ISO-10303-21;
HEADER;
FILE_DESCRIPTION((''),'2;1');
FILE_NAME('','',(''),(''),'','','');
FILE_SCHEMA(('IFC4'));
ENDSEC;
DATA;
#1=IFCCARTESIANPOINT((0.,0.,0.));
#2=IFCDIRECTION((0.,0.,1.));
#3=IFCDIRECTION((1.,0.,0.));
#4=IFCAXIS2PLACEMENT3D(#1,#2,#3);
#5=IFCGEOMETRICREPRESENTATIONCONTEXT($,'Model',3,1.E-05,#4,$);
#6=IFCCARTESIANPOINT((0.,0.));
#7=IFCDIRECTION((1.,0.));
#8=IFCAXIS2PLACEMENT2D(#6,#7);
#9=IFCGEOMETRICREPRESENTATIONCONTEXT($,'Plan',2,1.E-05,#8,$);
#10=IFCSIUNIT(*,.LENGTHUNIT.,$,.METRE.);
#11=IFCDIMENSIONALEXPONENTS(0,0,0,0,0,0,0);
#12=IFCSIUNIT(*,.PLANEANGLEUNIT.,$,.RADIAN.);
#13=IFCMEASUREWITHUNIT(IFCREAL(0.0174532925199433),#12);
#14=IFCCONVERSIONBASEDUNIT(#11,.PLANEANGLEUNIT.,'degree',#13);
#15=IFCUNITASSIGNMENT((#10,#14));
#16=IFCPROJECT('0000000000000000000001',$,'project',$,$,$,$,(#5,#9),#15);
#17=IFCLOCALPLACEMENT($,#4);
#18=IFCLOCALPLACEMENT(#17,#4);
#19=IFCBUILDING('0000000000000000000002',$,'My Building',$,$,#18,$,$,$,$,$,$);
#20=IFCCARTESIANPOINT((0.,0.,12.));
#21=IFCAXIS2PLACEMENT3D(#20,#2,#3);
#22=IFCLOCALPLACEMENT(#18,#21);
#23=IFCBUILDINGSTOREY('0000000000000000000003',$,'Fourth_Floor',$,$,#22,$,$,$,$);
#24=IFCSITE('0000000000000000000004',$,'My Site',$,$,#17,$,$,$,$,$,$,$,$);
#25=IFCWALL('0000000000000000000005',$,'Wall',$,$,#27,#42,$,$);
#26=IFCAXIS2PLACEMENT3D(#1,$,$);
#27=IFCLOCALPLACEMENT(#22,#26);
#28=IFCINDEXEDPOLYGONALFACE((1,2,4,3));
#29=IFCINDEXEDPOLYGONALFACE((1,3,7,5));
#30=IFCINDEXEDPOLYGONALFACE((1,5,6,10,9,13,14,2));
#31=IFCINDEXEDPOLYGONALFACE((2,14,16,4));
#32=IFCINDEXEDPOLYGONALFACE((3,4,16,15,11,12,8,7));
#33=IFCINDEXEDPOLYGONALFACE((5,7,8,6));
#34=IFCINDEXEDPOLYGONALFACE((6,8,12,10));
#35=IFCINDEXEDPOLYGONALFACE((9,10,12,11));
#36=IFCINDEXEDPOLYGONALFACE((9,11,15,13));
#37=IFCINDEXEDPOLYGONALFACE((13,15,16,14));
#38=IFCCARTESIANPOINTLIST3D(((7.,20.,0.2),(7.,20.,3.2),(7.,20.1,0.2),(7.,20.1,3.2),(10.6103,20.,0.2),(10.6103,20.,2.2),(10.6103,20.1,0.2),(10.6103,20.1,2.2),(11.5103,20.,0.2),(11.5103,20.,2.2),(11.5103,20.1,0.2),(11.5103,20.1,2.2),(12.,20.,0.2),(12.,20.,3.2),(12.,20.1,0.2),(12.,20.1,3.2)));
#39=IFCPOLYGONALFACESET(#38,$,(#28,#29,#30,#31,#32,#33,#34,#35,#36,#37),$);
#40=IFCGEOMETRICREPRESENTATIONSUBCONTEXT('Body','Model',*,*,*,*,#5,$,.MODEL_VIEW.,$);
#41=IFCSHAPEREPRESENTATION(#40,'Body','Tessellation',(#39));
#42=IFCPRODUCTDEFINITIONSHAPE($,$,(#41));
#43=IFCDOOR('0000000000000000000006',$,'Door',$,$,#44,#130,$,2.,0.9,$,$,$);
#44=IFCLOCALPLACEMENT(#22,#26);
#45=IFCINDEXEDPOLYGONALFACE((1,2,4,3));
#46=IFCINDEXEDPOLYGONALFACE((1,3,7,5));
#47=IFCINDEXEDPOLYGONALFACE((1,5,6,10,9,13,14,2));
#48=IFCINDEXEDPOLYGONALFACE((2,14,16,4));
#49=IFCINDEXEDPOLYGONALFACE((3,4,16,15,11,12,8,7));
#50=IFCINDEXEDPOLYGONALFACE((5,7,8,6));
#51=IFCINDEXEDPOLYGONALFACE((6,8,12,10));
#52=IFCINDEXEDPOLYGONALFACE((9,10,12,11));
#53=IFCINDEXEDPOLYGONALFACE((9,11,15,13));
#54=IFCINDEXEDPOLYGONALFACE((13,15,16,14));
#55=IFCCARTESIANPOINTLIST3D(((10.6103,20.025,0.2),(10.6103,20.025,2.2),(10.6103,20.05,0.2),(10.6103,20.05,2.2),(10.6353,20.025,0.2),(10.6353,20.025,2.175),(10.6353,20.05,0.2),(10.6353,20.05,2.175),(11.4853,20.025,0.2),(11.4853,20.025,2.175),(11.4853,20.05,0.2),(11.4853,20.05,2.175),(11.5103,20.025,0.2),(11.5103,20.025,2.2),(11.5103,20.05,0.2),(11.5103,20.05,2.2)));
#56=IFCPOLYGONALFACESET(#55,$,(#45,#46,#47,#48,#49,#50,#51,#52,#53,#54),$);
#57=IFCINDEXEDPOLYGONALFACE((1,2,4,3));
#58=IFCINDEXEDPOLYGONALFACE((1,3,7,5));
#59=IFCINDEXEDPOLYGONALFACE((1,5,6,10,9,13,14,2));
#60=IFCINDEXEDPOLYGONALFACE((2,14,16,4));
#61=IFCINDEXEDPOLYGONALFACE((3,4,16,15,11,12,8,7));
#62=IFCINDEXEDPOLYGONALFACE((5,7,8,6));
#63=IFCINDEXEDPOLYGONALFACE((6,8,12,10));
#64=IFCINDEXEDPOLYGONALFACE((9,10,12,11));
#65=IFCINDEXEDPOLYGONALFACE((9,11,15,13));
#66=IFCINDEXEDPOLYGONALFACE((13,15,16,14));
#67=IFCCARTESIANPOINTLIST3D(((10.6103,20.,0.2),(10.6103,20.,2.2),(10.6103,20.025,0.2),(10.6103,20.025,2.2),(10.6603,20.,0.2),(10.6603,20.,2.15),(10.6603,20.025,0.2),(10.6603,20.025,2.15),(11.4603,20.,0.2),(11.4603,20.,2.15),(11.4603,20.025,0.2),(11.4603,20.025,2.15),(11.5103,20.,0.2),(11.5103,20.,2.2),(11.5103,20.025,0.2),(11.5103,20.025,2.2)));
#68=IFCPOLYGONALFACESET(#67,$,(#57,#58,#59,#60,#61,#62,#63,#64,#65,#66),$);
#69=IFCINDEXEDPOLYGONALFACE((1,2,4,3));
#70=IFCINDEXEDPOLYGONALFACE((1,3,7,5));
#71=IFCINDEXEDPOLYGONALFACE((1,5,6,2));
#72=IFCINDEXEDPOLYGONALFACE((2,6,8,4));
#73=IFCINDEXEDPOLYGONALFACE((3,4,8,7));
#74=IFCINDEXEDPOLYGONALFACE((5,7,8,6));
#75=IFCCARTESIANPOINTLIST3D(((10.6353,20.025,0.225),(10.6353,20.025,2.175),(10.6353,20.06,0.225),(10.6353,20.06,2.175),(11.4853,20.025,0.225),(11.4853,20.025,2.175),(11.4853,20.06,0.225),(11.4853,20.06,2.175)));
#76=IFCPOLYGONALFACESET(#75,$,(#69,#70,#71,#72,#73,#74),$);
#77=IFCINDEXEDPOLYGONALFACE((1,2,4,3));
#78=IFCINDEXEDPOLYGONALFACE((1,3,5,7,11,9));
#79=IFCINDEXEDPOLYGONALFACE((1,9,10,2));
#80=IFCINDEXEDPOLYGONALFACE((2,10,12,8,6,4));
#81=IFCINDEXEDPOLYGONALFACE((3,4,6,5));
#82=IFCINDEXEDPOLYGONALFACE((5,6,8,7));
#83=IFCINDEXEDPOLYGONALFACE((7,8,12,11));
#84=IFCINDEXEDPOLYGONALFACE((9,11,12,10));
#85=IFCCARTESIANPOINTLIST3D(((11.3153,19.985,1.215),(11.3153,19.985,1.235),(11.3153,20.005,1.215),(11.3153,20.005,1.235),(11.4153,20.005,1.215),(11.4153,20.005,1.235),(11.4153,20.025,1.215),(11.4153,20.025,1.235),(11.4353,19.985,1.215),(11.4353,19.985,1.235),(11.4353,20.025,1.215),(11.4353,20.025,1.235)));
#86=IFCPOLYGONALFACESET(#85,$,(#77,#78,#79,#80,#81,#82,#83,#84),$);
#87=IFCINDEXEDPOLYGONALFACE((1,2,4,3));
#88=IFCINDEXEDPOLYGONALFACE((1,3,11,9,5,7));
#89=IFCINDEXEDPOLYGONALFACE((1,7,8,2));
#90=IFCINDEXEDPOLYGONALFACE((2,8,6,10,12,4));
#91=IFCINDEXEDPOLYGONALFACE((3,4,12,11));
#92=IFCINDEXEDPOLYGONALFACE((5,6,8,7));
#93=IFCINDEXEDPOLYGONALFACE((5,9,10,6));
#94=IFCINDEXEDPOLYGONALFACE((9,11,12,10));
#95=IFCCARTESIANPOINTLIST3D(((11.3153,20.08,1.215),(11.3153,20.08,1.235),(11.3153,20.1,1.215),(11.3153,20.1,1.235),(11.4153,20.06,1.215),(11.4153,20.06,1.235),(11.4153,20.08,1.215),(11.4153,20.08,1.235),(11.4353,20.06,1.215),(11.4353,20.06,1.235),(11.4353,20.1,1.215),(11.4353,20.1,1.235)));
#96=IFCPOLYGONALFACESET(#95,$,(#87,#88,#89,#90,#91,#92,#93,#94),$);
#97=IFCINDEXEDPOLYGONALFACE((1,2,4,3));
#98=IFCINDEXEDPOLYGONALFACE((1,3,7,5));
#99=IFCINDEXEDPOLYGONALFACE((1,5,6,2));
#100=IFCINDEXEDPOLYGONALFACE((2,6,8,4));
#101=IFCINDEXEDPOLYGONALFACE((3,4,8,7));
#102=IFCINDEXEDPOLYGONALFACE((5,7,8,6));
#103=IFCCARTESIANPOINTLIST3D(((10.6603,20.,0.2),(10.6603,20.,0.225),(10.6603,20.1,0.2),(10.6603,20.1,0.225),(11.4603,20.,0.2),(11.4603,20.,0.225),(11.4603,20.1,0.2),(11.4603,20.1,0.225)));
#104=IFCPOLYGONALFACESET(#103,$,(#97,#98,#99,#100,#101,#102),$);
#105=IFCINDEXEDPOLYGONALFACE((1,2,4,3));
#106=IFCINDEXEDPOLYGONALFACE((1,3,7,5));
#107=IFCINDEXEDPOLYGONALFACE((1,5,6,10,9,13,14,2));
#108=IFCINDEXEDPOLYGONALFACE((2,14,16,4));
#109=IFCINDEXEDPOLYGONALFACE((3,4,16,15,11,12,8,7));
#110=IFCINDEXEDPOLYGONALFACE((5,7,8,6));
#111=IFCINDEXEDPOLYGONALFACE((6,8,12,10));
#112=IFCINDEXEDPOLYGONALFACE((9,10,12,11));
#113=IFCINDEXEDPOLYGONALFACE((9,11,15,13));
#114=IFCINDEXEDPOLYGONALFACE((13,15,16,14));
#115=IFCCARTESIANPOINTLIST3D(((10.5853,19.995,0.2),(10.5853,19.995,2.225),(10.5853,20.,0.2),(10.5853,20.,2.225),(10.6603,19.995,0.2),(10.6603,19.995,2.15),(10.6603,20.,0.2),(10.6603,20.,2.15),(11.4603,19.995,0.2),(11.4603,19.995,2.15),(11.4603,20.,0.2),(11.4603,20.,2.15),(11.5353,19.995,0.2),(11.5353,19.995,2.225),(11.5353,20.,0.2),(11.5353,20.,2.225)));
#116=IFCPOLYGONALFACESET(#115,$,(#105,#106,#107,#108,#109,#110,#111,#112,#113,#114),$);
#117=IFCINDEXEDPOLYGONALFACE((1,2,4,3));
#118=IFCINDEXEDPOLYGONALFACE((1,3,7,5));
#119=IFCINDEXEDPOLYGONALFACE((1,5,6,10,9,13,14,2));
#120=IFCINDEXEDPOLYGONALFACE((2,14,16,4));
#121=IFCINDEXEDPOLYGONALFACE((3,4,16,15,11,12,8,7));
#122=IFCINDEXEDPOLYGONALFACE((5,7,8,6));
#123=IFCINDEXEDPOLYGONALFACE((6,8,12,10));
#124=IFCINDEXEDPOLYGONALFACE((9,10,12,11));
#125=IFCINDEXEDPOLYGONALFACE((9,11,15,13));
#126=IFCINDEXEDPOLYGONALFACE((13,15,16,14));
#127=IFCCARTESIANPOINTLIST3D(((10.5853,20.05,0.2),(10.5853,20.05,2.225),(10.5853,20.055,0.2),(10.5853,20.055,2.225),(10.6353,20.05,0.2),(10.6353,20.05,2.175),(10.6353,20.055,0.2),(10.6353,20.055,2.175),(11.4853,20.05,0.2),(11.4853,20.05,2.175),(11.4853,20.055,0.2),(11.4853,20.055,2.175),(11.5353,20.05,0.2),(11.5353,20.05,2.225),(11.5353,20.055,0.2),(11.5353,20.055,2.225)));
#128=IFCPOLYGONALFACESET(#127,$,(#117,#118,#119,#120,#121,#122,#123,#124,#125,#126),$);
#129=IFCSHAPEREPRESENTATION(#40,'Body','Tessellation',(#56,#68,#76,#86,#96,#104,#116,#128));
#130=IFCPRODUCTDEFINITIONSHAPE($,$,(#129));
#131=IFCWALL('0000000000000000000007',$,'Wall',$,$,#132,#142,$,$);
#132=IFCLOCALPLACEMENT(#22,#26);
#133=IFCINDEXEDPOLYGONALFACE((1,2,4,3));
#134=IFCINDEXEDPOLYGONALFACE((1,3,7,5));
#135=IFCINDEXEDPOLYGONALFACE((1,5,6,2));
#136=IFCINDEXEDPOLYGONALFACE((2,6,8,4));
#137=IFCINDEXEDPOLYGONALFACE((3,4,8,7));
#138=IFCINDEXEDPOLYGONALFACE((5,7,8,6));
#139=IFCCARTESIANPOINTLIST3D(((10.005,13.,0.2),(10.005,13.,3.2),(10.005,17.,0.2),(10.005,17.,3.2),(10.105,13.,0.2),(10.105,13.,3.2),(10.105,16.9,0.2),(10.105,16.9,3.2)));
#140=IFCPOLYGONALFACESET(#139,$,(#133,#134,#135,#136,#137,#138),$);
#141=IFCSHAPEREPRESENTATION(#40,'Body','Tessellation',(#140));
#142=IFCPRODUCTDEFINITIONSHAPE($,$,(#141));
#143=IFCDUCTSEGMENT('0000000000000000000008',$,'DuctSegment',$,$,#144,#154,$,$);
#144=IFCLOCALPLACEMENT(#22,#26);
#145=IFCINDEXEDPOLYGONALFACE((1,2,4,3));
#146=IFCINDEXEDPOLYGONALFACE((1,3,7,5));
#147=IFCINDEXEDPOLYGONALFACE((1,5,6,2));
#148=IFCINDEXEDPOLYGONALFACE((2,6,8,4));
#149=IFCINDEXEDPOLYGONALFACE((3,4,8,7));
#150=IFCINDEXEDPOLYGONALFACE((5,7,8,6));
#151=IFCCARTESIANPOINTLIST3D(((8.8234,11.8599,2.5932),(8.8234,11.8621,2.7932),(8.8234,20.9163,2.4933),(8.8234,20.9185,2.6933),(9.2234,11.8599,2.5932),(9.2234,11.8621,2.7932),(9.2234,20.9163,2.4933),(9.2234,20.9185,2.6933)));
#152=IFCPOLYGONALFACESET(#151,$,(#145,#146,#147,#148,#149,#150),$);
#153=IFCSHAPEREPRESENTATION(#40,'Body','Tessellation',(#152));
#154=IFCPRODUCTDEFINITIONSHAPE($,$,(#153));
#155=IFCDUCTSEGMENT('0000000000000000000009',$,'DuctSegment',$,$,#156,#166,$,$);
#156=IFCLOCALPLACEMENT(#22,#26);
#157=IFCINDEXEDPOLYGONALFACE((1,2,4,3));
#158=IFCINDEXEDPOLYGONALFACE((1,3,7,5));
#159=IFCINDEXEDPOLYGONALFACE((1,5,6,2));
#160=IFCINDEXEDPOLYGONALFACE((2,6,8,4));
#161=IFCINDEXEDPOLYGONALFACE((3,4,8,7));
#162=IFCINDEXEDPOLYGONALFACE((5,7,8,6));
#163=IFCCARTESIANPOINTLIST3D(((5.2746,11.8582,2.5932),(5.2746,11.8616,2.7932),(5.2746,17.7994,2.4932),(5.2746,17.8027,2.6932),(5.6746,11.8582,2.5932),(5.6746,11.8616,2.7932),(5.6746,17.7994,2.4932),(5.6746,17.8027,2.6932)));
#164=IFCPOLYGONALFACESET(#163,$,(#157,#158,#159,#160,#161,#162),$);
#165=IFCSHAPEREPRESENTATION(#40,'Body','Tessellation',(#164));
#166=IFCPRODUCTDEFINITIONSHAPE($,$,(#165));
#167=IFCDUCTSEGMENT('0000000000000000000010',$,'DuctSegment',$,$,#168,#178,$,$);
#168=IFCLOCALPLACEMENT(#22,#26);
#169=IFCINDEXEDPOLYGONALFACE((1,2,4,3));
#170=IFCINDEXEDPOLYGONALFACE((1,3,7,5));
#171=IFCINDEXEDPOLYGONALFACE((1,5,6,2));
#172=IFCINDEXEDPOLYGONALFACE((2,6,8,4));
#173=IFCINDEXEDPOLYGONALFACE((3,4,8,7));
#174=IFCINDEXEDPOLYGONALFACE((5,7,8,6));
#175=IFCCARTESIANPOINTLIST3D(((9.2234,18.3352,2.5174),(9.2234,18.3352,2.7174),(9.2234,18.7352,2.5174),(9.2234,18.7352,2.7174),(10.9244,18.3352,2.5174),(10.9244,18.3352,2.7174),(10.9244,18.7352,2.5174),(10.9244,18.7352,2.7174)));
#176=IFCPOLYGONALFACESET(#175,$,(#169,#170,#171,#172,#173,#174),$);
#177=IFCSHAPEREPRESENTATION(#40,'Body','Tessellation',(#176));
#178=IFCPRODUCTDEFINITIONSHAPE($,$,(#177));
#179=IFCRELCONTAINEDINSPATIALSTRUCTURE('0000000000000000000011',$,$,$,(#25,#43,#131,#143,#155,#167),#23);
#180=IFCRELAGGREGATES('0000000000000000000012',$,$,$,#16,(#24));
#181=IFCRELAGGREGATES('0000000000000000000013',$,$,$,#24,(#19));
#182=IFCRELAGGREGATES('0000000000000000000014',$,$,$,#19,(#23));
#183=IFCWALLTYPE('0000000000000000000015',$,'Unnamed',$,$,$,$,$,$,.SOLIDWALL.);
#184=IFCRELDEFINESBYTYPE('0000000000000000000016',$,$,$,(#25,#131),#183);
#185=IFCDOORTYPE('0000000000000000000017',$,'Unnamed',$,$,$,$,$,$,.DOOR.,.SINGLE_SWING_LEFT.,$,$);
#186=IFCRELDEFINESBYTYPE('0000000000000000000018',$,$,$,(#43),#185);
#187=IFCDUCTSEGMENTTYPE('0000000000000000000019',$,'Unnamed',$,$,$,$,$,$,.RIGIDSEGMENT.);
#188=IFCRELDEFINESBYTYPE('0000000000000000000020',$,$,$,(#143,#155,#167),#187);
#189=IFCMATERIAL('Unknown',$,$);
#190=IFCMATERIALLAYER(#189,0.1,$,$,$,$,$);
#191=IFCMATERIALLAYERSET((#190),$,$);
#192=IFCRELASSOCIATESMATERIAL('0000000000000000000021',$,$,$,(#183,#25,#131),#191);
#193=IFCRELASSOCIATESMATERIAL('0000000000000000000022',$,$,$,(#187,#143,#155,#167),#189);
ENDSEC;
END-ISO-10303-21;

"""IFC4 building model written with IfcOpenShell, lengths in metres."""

from ifc_helpers import new_model, entity, si_unit, converted_unit, frame, origin_with_axes, origin_2d_with_axis, place, context, subcontext, project, spatial, line, indexed_curve, rectangle, outline, extrude, shape, source, transform, mapped, material, layer, layer_set, layer_usage, material_profile, profile_set, profile_usage, type_object, type_shapes, element, fill, save


model = new_model("IFC4")

# Units and contexts
model_context = context("Model", 3, precision=1e-05, world=origin_with_axes())
plan_context = context("Plan", 2, precision=1e-05, world=origin_2d_with_axis())
body_context_1 = subcontext(model_context, "Body", "Model", "MODEL_VIEW")
body_context_2 = subcontext(plan_context, "Body", "Plan", "PLAN_VIEW")
ifc_project = project(units=[si_unit("LENGTHUNIT", "METRE"), converted_unit("PLANEANGLEUNIT", "degree", entity("IfcReal", 0.0174532925199433), si_unit("PLANEANGLEUNIT", "RADIAN"), dimensions=[0, 0, 0, 0, 0, 0, 0])], contexts=[model_context, plan_context])

# Site, building, storey
site_placement = place(None, origin_with_axes())
site = spatial("IfcSite", under=ifc_project, at=site_placement, Name="My Site")
building_placement = place(site_placement, origin_with_axes())
building = spatial("IfcBuilding", under=site, at=building_placement, Name="My Building")
storey_placement = place(building_placement, frame((0.0, 0.0, 12.0), z_axis=(0.0, 0.0, 1.0), x_axis=(1.0, 0.0, 0.0)))
storey = spatial("IfcBuildingStorey", under=building, at=storey_placement, Name="Fourth_Floor")

# Shared definitions
ifc_material = material(Name="Unknown")
ifc_layer = layer(ifc_material, 0.1)
ifc_layer_set = layer_set([ifc_layer])
wall_type = type_object("IfcWallType", Name="Unnamed", PredefinedType="SOLIDWALL", material=ifc_layer_set)
shared_shape_1 = source(origin_with_axes(), body_context_1, "Body", "SweptSolid", [
    extrude(outline(indexed_curve([(0.0, 0.0), (0.9, 0.0), (0.9, 2.0), (0.0, 2.0)], segments=[line(1, 2, 3, 4, 1)])), frame((0.0, -0.6, 0.0), z_axis=(0.0, -1.0, 0.0), x_axis=(1.0, 0.0, 0.0)), (0.0, 0.0, -1.0), 1.2),
])
door_type = type_object("IfcDoorType", Name="Unnamed", OperationType="SINGLE_SWING_LEFT", PredefinedType="DOOR")
shared_shape_2 = source(origin_with_axes(), body_context_1, "Body", "SweptSolid", [
    extrude(outline(indexed_curve([(0.0, 0.0), (0.0, 2.0), (0.9, 2.0), (0.9, 0.0), (0.875, 0.0), (0.875, 1.975), (0.025, 1.975), (0.025, 0.0)], segments=[line(1, 2, 3, 4, 5, 6, 7, 8, 1)])), frame((0.0, 0.025, 0.0), z_axis=(0.0, -1.0, 0.0), x_axis=(1.0, 0.0, 0.0)), (0.0, 0.0, -1.0), 0.025),
    extrude(outline(indexed_curve([(0.0, 0.0), (0.0, 2.0), (0.9, 2.0), (0.9, 0.0), (0.85, 0.0), (0.85, 1.95), (0.05, 1.95), (0.05, 0.0)], segments=[line(1, 2, 3, 4, 5, 6, 7, 8, 1)])), frame((0.0, 0.0, 0.0), z_axis=(0.0, -1.0, 0.0), x_axis=(1.0, 0.0, 0.0)), (0.0, 0.0, -1.0), 0.025),
    extrude(outline(indexed_curve([(0.0, 0.0), (0.85, 0.0), (0.85, 0.035), (0.0, 0.035)], segments=[line(1, 2, 3, 4, 1)])), frame((0.025, 0.025, 0.025), z_axis=(0.0, 0.0, 1.0), x_axis=(1.0, 0.0, 0.0)), (0.0, 0.0, 1.0), 1.95),
    extrude(outline(indexed_curve([(0.0, 0.0), (0.0, -0.04), (-0.12, -0.04), (-0.12, -0.02), (-0.02, -0.02), (-0.02, 0.0)], segments=[line(1, 2, 3, 4, 5, 6, 1)])), frame((0.825, 0.025, 1.015), z_axis=(0.0, 0.0, 1.0), x_axis=(1.0, 0.0, 0.0)), (0.0, 0.0, 1.0), 0.02),
    extrude(outline(indexed_curve([(0.0, 0.0), (0.0, 0.04), (-0.12, 0.04), (-0.12, 0.02), (-0.02, 0.02), (-0.02, 0.0)], segments=[line(1, 2, 3, 4, 5, 6, 1)])), frame((0.825, 0.06, 1.015), z_axis=(0.0, 0.0, 1.0), x_axis=(1.0, 0.0, 0.0)), (0.0, 0.0, 1.0), 0.02),
    extrude(outline(indexed_curve([(0.0, 0.0), (0.8, 0.0), (0.8, 0.1), (0.0, 0.1)], segments=[line(1, 2, 3, 4, 1)])), frame((0.05, 0.0, 0.0), z_axis=(0.0, 0.0, 1.0), x_axis=(1.0, 0.0, 0.0)), (0.0, 0.0, 1.0), 0.025),
    extrude(outline(indexed_curve([(0.0, 0.0), (0.0, 2.025), (0.95, 2.025), (0.95, 0.0), (0.875, 0.0), (0.875, 1.95), (0.075, 1.95), (0.075, 0.0)], segments=[line(1, 2, 3, 4, 5, 6, 7, 8, 1)])), frame((-0.025, -0.005, 0.0), z_axis=(0.0, -1.0, 0.0), x_axis=(1.0, 0.0, 0.0)), (0.0, 0.0, -1.0), 0.005),
    extrude(outline(indexed_curve([(0.0, 0.0), (0.0, 2.025), (0.95, 2.025), (0.95, 0.0), (0.9, 0.0), (0.9, 1.975), (0.05, 1.975), (0.05, 0.0)], segments=[line(1, 2, 3, 4, 5, 6, 7, 8, 1)])), frame((-0.025, 0.05, 0.0), z_axis=(0.0, -1.0, 0.0), x_axis=(1.0, 0.0, 0.0)), (0.0, 0.0, -1.0), 0.005),
])
shared_shape_3 = source(origin_with_axes(), body_context_2, "Body", "Curve2D", [
    entity("IfcIndexedPolyCurve", entity("IfcCartesianPointList2D", [[0.0, 0.0], [0.0, 0.05], [0.025, 0.05], [0.025, 0.025], [0.05, 0.025], [0.05, 0.0]]), [entity("IfcLineIndex", [1, 2, 3, 4, 5, 6, 1])]),
    entity("IfcIndexedPolyCurve", entity("IfcCartesianPointList2D", [[0.9, 0.0], [0.9, 0.05], [0.875, 0.05], [0.875, 0.025], [0.85, 0.025], [0.85, 0.0]]), [entity("IfcLineIndex", [1, 2, 3, 4, 5, 6, 1])]),
    entity("IfcTrimmedCurve", entity("IfcEllipse", entity("IfcAxis2Placement2D", entity("IfcCartesianPoint", [0.06, 0.05]), entity("IfcDirection", [1.0, 0.0])), 0.815, 0.85), [entity("IfcCartesianPoint", [0.875, 0.05])], [entity("IfcCartesianPoint", [0.06, 0.9])], True, "CARTESIAN"),
    entity("IfcIndexedPolyCurve", entity("IfcCartesianPointList2D", [[0.025, 0.05], [0.06, 0.05], [0.06, 0.9], [0.025, 0.9]]), [entity("IfcLineIndex", [1, 2, 3, 4, 1])]),
])
type_shapes(door_type, [shared_shape_2, shared_shape_3])

# Wall, opening, door
ifc_layer_usage_1 = layer_usage(ifc_layer_set, "AXIS2", "POSITIVE", 0.0)
wall_1_placement = place(storey_placement, frame((7.0, 20.0, 0.2), z_axis=(0.0, 0.0, 1.0), x_axis=(1.0, 0.0, 0.0)))
wall_1 = element("IfcWall", 1, at=wall_1_placement, inside=storey, type_object=wall_type, material=ifc_layer_usage_1, Name="Wall", context=body_context_1, shape_type="SweptSolid", body=[
    extrude(outline(indexed_curve([(0.0, 0.0), (0.0, 0.1), (5.0, 0.1), (5.0, 0.0)], segments=[line(1, 2, 3, 4, 1)])), origin_with_axes(), (0.0, 0.0, 1.0), 3.0),
])
opening_1_placement = place(wall_1_placement, frame((3.6103, 0.0, 0.0), z_axis=(0.0, 0.0, 1.0), x_axis=(1.0, 0.0, 0.0)))
opening_1 = element("IfcOpeningElement", 2, at=opening_1_placement, cuts=wall_1, PredefinedType="OPENING", context=body_context_1, shape_type="MappedRepresentation", body=[
    mapped(shared_shape_1, transform((0.0, 0.0, 0.0), x_axis=(1.0, 0.0, 0.0), y_axis=(0.0, 1.0, 0.0), z_axis=(0.0, 0.0, 1.0), scale=1.0)),
])
door_1_placement = place(opening_1_placement, origin_with_axes())
door_1 = element("IfcDoor", 3, at=door_1_placement, inside=storey, type_object=door_type, Name="Door", OverallHeight=2.0, OverallWidth=0.9, shapes=[
    shape(body_context_1, "Body", "MappedRepresentation", [mapped(shared_shape_2, transform((0.0, 0.0, 0.0), x_axis=(1.0, 0.0, 0.0), y_axis=(0.0, 1.0, 0.0), z_axis=(0.0, 0.0, 1.0), scale=1.0))]),
    shape(body_context_2, "Body", "MappedRepresentation", [mapped(shared_shape_3, transform((0.0, 0.0, 0.0), x_axis=(1.0, 0.0, 0.0), y_axis=(0.0, 1.0, 0.0), z_axis=(0.0, 0.0, 1.0), scale=1.0))]),
])
fill(opening_1, door_1)

# Wall
ifc_layer_usage_2 = layer_usage(ifc_layer_set, "AXIS2", "POSITIVE", 0.0)
wall_2_placement = place(storey_placement, frame((10.005, 17.0, 0.2), z_axis=(0.0, 0.0, 1.0), x_axis=(0.0, -1.0, 0.0)))
element("IfcWall", 4, at=wall_2_placement, inside=storey, type_object=wall_type, material=ifc_layer_usage_2, Name="Wall", context=body_context_1, shape_type="SweptSolid", body=[
    extrude(outline(indexed_curve([(0.0, 0.0), (0.1, 0.1), (4.0, 0.1), (4.0, 0.0)], segments=[line(1, 2, 3, 4, 1)])), origin_with_axes(), (0.0, 0.0, 1.0), 3.0),
])

# Duct segments
ifc_material_profile_1 = material_profile(ifc_material, rectangle(XDim=0.4, YDim=0.2))
ifc_profile_set_1 = profile_set([ifc_material_profile_1])
ifc_profile_usage_1 = profile_usage(ifc_profile_set_1, cardinal=5)
duct_segment_type = type_object("IfcDuctSegmentType", Name="Unnamed", PredefinedType="RIGIDSEGMENT", material=ifc_profile_set_1)
duct_segment_1_placement = place(storey_placement, frame((9.0234, 20.9174, 2.5933), z_axis=(0.0, -0.999939, 0.011037), x_axis=(1.0, 0.0, 0.0)))
element("IfcDuctSegment", 5, at=duct_segment_1_placement, inside=storey, type_object=duct_segment_type, material=ifc_profile_usage_1, Name="DuctSegment", context=body_context_1, shape_type="SweptSolid", body=[
    extrude(rectangle(XDim=0.4, YDim=0.2), origin_with_axes(), (0.0, 0.0, 1.0), 9.057),
])
ifc_profile_usage_2 = profile_usage(ifc_profile_set_1, cardinal=5)
duct_segment_2_placement = place(storey_placement, frame((5.4746, 11.8599, 2.6932), z_axis=(0.0, 0.999858, -0.01683), x_axis=(-1.0, 0.0, 0.0)))
element("IfcDuctSegment", 6, at=duct_segment_2_placement, inside=storey, type_object=duct_segment_type, material=ifc_profile_usage_2, Name="DuctSegment", context=body_context_1, shape_type="SweptSolid", body=[
    extrude(rectangle(XDim=0.4, YDim=0.2), origin_with_axes(), (0.0, 0.0, 1.0), 5.942),
])
ifc_profile_usage_3 = profile_usage(ifc_profile_set_1, cardinal=5)
duct_segment_3_placement = place(storey_placement, frame((9.2234, 18.5352, 2.6174), z_axis=(1.0, -0.000001, 0.000001), x_axis=(0.000001, 1.0, 0.0)))
element("IfcDuctSegment", 7, at=duct_segment_3_placement, inside=storey, type_object=duct_segment_type, material=ifc_profile_usage_3, Name="DuctSegment", context=body_context_1, shape_type="SweptSolid", body=[
    extrude(rectangle(XDim=0.4, YDim=0.2), origin_with_axes(), (0.0, 0.0, 1.0), 1.701),
])

save(model, "model.ifc")
